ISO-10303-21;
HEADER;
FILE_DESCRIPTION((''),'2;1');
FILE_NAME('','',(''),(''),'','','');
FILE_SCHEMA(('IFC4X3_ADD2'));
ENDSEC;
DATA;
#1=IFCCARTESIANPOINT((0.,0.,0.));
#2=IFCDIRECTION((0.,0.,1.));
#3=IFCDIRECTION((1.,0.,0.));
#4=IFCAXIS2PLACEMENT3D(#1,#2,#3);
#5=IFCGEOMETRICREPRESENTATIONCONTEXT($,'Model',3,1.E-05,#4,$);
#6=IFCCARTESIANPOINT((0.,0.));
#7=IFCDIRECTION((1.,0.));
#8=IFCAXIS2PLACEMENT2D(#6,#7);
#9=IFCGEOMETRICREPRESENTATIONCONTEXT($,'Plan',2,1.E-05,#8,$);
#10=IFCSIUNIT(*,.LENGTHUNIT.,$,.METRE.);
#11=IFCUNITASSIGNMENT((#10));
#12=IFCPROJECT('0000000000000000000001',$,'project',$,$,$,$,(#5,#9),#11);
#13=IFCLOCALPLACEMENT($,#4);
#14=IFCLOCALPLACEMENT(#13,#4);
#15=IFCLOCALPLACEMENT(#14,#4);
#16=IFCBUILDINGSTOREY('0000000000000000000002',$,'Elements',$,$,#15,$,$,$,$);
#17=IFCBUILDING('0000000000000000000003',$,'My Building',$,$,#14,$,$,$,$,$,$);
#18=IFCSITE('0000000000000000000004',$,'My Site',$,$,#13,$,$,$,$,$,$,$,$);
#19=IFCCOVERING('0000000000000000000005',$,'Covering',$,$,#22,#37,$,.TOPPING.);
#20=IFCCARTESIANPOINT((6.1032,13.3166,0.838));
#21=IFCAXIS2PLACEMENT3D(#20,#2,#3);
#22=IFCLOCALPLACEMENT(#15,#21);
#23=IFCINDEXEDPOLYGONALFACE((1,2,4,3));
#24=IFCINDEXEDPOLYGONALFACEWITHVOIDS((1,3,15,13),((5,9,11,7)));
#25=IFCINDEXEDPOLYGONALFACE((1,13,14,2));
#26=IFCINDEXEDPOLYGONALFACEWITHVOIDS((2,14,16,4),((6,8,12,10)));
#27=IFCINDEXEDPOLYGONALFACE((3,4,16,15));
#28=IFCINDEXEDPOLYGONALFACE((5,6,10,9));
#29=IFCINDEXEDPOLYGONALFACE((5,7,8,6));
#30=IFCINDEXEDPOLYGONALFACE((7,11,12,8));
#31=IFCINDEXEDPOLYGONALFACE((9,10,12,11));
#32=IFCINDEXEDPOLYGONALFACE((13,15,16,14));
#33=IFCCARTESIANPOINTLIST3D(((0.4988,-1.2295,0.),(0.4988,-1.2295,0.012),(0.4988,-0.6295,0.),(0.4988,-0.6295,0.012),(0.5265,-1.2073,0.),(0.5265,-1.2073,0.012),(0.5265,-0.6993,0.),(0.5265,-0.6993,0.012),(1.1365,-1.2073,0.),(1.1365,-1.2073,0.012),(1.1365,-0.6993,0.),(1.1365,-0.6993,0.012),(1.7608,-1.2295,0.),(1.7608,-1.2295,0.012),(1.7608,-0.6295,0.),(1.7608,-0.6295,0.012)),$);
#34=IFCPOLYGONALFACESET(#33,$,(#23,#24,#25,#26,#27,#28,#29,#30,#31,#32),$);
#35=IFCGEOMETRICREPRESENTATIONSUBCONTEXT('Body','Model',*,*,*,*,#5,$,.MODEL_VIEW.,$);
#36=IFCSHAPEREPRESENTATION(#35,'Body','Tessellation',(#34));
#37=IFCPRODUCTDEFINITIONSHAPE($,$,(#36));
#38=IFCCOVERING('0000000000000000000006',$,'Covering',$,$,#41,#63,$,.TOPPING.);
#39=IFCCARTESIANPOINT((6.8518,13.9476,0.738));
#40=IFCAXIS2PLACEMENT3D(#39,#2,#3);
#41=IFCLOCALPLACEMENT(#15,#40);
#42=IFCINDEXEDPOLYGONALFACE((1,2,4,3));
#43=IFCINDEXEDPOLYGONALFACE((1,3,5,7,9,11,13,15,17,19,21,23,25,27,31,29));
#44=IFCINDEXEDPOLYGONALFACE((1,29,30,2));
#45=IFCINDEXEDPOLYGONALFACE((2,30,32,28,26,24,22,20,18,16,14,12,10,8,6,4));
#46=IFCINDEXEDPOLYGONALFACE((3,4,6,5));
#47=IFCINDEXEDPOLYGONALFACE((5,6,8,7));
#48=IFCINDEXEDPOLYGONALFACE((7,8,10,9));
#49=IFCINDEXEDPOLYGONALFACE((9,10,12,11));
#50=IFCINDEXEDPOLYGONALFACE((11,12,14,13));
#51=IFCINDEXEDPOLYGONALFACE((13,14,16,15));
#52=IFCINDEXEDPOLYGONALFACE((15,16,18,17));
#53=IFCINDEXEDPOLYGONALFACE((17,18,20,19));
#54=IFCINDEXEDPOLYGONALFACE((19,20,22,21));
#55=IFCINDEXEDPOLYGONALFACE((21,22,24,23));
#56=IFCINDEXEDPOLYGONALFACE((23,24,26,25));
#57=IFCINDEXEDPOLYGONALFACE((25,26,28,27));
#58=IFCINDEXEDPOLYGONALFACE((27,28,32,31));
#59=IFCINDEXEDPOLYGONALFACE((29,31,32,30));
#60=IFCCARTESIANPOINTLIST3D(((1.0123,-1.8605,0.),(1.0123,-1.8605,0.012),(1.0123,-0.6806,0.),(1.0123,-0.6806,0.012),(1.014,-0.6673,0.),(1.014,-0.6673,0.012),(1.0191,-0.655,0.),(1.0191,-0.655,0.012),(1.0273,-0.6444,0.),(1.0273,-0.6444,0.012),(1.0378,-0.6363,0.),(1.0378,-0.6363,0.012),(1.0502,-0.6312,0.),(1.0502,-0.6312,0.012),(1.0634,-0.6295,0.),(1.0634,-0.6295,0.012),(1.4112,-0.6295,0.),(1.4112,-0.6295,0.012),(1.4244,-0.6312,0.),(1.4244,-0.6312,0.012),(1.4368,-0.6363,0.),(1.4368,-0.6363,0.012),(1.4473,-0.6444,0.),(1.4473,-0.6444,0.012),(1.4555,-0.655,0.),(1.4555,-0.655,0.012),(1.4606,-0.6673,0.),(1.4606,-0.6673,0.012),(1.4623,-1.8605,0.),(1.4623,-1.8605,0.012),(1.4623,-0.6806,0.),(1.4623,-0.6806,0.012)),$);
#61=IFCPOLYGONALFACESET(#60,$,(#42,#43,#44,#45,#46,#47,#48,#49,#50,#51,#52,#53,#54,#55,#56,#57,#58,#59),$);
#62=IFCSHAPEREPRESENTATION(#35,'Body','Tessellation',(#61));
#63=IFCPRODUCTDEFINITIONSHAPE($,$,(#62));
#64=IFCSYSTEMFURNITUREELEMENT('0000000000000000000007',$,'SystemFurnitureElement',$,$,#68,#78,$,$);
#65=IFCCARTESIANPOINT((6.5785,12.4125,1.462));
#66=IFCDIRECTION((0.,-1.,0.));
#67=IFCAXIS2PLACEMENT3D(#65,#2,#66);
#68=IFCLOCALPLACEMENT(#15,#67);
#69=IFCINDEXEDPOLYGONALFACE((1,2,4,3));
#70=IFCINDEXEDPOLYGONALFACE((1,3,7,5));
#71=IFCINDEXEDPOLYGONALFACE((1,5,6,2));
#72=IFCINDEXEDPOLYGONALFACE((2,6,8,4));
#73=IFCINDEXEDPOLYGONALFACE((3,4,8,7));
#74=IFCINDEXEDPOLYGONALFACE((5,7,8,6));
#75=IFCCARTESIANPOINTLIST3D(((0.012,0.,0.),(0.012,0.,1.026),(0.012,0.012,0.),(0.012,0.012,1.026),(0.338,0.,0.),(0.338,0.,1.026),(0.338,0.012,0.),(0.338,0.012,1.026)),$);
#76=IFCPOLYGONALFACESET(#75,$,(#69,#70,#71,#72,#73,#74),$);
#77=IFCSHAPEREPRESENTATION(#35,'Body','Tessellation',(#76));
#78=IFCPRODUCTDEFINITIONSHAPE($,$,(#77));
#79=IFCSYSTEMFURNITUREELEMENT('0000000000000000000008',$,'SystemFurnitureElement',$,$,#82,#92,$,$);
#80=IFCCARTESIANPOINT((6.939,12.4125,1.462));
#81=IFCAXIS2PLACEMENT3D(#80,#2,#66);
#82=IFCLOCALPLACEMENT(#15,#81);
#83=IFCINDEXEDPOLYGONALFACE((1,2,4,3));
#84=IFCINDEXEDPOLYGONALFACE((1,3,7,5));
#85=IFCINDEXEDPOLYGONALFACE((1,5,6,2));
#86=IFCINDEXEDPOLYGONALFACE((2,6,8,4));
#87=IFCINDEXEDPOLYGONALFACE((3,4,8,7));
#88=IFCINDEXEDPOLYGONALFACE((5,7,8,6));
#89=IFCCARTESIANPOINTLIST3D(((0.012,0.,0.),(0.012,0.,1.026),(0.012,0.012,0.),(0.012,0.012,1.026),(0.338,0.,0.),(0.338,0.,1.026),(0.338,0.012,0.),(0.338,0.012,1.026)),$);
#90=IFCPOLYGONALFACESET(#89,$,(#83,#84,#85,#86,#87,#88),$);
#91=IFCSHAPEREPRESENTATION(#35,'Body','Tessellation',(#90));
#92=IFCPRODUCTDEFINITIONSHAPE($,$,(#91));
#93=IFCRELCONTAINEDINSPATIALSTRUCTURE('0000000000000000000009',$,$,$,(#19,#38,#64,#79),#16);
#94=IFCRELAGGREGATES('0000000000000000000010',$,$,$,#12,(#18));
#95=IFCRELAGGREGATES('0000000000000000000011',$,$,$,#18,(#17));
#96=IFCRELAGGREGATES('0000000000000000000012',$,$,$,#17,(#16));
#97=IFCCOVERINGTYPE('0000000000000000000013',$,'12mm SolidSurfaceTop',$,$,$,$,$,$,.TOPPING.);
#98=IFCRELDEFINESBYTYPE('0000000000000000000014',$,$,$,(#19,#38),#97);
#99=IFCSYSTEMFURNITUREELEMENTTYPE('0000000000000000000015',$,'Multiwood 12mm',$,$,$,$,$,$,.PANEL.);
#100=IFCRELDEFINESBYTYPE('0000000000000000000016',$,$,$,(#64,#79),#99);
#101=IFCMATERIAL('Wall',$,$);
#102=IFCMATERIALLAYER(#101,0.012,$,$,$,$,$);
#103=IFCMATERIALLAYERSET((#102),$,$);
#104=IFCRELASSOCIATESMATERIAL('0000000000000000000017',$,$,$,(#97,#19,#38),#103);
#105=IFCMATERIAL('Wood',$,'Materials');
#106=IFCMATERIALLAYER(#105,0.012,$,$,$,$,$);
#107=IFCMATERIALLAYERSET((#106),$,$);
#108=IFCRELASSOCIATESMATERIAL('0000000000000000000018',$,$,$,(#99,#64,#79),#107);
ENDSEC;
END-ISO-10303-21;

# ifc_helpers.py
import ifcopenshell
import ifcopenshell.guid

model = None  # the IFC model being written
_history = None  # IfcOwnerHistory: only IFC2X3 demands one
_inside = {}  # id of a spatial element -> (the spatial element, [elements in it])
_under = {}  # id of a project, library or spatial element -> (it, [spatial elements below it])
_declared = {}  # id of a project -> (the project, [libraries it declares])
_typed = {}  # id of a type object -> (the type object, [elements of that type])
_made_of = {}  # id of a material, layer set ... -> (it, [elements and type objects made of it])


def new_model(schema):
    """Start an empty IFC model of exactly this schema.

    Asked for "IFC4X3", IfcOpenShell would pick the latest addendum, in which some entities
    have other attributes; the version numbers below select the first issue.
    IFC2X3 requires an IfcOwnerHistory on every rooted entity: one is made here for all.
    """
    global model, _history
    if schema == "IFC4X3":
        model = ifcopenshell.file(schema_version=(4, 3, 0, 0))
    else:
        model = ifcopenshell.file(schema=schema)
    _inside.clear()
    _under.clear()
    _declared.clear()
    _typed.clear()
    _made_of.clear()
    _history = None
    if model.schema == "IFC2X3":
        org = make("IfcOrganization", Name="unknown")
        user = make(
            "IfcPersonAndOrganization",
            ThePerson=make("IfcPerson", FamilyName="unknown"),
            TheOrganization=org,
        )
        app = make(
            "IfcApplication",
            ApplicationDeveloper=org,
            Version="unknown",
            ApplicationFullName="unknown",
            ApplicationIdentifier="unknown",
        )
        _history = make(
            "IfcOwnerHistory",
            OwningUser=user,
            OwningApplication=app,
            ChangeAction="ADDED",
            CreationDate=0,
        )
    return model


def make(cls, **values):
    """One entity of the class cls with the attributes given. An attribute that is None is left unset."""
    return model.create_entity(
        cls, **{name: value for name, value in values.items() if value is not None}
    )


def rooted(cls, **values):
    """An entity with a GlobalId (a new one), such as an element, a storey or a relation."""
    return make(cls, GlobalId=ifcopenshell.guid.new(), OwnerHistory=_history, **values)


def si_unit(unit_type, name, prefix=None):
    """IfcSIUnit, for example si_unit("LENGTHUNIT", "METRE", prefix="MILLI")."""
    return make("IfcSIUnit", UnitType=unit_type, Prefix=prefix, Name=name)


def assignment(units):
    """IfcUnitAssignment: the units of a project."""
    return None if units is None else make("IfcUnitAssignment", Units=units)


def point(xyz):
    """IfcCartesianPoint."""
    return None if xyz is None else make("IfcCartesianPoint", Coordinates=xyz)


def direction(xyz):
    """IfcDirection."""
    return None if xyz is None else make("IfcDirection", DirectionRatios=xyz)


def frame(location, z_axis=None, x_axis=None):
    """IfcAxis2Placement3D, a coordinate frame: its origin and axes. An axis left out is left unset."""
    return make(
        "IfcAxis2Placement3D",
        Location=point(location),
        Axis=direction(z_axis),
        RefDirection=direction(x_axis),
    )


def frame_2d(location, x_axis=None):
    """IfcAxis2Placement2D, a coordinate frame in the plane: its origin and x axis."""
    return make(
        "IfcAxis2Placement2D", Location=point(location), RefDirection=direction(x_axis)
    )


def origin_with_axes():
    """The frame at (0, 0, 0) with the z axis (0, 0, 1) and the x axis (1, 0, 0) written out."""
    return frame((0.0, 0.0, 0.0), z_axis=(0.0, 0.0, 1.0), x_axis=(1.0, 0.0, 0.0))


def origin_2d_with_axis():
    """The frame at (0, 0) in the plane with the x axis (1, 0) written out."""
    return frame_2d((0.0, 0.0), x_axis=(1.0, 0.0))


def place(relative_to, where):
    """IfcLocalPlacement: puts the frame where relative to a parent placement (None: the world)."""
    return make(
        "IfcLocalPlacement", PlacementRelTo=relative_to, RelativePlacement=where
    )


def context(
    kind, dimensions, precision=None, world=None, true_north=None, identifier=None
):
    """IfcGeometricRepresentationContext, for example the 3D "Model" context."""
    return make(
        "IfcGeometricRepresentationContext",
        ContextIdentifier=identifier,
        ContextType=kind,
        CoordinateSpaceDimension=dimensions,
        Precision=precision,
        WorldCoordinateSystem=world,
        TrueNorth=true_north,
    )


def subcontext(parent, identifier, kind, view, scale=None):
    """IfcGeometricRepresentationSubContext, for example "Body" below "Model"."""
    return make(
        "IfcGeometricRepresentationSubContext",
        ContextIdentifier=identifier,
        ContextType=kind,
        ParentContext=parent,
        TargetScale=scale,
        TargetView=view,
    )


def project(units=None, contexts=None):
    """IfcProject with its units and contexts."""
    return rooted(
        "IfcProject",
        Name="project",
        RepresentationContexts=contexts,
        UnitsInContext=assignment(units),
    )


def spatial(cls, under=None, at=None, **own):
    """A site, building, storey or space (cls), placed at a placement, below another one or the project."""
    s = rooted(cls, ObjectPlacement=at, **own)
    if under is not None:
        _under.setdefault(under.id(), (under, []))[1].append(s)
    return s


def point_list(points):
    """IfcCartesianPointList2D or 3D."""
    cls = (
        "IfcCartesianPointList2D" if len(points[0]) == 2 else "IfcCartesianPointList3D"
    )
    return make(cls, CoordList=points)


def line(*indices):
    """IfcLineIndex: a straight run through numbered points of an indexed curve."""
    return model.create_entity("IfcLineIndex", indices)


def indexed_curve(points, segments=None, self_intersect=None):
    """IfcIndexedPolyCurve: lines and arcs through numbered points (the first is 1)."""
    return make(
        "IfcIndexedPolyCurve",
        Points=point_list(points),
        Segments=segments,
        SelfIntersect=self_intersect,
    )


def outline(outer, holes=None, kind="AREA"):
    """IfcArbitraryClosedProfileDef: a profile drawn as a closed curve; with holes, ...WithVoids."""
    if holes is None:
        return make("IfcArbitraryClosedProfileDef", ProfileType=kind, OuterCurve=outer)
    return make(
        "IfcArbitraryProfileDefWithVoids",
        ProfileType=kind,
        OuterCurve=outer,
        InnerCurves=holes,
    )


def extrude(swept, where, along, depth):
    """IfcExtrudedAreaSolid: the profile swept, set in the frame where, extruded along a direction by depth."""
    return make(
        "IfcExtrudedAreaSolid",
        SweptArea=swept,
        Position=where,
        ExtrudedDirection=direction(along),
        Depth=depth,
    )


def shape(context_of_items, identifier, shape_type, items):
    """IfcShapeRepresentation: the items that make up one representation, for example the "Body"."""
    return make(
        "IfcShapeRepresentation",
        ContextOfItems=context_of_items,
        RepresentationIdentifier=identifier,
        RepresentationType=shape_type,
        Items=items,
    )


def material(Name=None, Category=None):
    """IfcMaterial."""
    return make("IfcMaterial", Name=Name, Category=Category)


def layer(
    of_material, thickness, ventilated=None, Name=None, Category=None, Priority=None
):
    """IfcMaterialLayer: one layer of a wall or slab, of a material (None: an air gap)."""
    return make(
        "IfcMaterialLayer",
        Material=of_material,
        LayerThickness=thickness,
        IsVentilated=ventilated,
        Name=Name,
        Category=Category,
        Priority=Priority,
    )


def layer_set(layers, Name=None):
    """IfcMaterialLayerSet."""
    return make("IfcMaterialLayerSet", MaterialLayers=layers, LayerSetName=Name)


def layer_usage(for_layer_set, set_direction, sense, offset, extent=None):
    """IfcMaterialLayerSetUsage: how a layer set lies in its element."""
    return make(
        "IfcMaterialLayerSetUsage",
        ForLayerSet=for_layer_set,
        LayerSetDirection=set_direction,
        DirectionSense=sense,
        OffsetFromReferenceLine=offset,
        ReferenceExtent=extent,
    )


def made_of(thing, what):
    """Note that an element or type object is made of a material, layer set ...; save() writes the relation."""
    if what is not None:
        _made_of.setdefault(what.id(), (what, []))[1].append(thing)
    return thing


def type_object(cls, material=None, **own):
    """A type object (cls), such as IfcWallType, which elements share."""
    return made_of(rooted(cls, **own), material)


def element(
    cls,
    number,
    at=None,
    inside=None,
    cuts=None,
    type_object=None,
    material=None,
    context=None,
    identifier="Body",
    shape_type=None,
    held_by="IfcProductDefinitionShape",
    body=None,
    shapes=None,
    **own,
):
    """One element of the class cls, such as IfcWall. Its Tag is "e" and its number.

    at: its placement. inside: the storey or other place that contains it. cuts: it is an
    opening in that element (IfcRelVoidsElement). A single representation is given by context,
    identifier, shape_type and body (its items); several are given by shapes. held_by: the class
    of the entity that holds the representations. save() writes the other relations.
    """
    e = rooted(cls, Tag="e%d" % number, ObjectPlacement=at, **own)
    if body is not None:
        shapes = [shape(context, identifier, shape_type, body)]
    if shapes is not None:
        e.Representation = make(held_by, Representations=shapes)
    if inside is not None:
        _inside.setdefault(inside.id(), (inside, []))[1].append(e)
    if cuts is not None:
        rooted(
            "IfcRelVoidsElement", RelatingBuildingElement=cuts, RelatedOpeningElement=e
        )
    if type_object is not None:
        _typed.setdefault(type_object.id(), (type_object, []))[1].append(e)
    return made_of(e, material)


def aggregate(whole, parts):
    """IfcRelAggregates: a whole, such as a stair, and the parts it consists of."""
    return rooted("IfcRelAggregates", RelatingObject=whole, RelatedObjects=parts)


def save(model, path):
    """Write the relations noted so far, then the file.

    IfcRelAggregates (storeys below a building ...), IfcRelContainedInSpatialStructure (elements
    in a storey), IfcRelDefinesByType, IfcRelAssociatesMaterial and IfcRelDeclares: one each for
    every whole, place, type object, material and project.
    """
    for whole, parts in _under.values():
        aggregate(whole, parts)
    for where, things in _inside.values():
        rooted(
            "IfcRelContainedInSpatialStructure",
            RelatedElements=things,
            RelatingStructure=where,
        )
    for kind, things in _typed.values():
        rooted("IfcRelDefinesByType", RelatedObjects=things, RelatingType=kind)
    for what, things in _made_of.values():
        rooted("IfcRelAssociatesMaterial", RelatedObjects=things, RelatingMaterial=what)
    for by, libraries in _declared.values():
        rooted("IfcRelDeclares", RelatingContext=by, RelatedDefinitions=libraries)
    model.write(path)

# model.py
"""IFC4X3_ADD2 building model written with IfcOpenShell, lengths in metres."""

from ifc_helpers import new_model, si_unit, frame, origin_with_axes, origin_2d_with_axis, place, context, subcontext, project, spatial, line, indexed_curve, outline, extrude, material, layer, layer_set, layer_usage, type_object, element, save


model = new_model("IFC4X3_ADD2")

# Units and contexts
model_context = context("Model", 3, precision=1e-05, world=origin_with_axes())
plan_context = context("Plan", 2, precision=1e-05, world=origin_2d_with_axis())
body_context = subcontext(model_context, "Body", "Model", "MODEL_VIEW")
ifc_project = project(units=[si_unit("LENGTHUNIT", "METRE")], contexts=[model_context, plan_context])

# Site, building, storey
site_placement = place(None, origin_with_axes())
site = spatial("IfcSite", under=ifc_project, at=site_placement, Name="My Site")
building_placement = place(site_placement, origin_with_axes())
building = spatial("IfcBuilding", under=site, at=building_placement, Name="My Building")
storey_placement = place(building_placement, origin_with_axes())
storey = spatial("IfcBuildingStorey", under=building, at=storey_placement, Name="Elements")

# Coverings
ifc_material_1 = material(Name="Wall")
ifc_layer_1 = layer(ifc_material_1, 0.012)
ifc_layer_set_1 = layer_set([ifc_layer_1])
ifc_layer_usage_1 = layer_usage(ifc_layer_set_1, "AXIS3", "POSITIVE", 0.0)
covering_type_1 = type_object("IfcCoveringType", Name="12mm SolidSurfaceTop", PredefinedType="TOPPING", material=ifc_layer_set_1)
covering_1_placement = place(storey_placement, frame((6.1032, 13.3166, 0.838), z_axis=(0.0, 0.0, 1.0), x_axis=(1.0, 0.0, 0.0)))
element("IfcCovering", 1, at=covering_1_placement, inside=storey, type_object=covering_type_1, material=ifc_layer_usage_1, Name="Covering", PredefinedType="TOPPING", context=body_context, shape_type="SweptSolid", body=[
    extrude(outline(indexed_curve([(0.4988, -1.2295), (1.7608, -1.2295), (1.7608, -0.6295), (0.4988, -0.6295), (0.4988, -1.2295)]), holes=[indexed_curve([(0.5265, -1.2073), (1.1365, -1.2073), (1.1365, -0.6993), (0.5265, -0.6993), (0.5265, -1.2073)])]), None, (0.0, 0.0, 1.0), 0.012),
])
ifc_layer_usage_2 = layer_usage(ifc_layer_set_1, "AXIS3", "POSITIVE", 0.0)
covering_2_placement = place(storey_placement, frame((6.8518, 13.9476, 0.738), z_axis=(0.0, 0.0, 1.0), x_axis=(1.0, 0.0, 0.0)))
element("IfcCovering", 2, at=covering_2_placement, inside=storey, type_object=covering_type_1, material=ifc_layer_usage_2, Name="Covering", PredefinedType="TOPPING", context=body_context, shape_type="SweptSolid", body=[
    extrude(outline(indexed_curve([(1.0634, -0.6295), (1.0502, -0.6312), (1.0378, -0.6363), (1.0273, -0.6444), (1.0191, -0.655), (1.014, -0.6673), (1.0123, -0.6806), (1.0123, -1.8605), (1.4623, -1.8605), (1.4623, -0.6806), (1.4606, -0.6673), (1.4555, -0.655), (1.4473, -0.6444), (1.4368, -0.6363), (1.4244, -0.6312), (1.4112, -0.6295), (1.0634, -0.6295)])), None, (0.0, 0.0, 1.0), 0.012),
])

# System furniture elements
ifc_material_2 = material(Name="Wood", Category="Materials")
ifc_layer_2 = layer(ifc_material_2, 0.012)
ifc_layer_set_2 = layer_set([ifc_layer_2])
system_furniture_element_type_1 = type_object("IfcSystemFurnitureElementType", Name="Multiwood 12mm", PredefinedType="PANEL", material=ifc_layer_set_2)
ifc_layer_usage_3 = layer_usage(ifc_layer_set_2, "AXIS2", "POSITIVE", 0.0)
system_furniture_element_1_placement = place(storey_placement, frame((6.5785, 12.4125, 1.462), z_axis=(0.0, 0.0, 1.0), x_axis=(0.0, -1.0, 0.0)))
element("IfcSystemFurnitureElement", 3, at=system_furniture_element_1_placement, inside=storey, type_object=system_furniture_element_type_1, material=ifc_layer_usage_3, Name="SystemFurnitureElement", context=body_context, shape_type="SweptSolid", body=[
    extrude(outline(indexed_curve([(0.012, 0.0), (0.012, 0.012), (0.338, 0.012), (0.338, 0.0)], segments=[line(1, 2, 3, 4, 1)])), origin_with_axes(), (0.0, 0.0, 1.0), 1.026),
])
ifc_layer_usage_4 = layer_usage(ifc_layer_set_2, "AXIS2", "POSITIVE", 0.0)
system_furniture_element_2_placement = place(storey_placement, frame((6.939, 12.4125, 1.462), z_axis=(0.0, 0.0, 1.0), x_axis=(0.0, -1.0, 0.0)))
element("IfcSystemFurnitureElement", 4, at=system_furniture_element_2_placement, inside=storey, type_object=system_furniture_element_type_1, material=ifc_layer_usage_4, Name="SystemFurnitureElement", context=body_context, shape_type="SweptSolid", body=[
    extrude(outline(indexed_curve([(0.012, 0.0), (0.012, 0.012), (0.338, 0.012), (0.338, 0.0)], segments=[line(1, 2, 3, 4, 1)])), origin_with_axes(), (0.0, 0.0, 1.0), 1.026),
])

save(model, "model.ifc")
